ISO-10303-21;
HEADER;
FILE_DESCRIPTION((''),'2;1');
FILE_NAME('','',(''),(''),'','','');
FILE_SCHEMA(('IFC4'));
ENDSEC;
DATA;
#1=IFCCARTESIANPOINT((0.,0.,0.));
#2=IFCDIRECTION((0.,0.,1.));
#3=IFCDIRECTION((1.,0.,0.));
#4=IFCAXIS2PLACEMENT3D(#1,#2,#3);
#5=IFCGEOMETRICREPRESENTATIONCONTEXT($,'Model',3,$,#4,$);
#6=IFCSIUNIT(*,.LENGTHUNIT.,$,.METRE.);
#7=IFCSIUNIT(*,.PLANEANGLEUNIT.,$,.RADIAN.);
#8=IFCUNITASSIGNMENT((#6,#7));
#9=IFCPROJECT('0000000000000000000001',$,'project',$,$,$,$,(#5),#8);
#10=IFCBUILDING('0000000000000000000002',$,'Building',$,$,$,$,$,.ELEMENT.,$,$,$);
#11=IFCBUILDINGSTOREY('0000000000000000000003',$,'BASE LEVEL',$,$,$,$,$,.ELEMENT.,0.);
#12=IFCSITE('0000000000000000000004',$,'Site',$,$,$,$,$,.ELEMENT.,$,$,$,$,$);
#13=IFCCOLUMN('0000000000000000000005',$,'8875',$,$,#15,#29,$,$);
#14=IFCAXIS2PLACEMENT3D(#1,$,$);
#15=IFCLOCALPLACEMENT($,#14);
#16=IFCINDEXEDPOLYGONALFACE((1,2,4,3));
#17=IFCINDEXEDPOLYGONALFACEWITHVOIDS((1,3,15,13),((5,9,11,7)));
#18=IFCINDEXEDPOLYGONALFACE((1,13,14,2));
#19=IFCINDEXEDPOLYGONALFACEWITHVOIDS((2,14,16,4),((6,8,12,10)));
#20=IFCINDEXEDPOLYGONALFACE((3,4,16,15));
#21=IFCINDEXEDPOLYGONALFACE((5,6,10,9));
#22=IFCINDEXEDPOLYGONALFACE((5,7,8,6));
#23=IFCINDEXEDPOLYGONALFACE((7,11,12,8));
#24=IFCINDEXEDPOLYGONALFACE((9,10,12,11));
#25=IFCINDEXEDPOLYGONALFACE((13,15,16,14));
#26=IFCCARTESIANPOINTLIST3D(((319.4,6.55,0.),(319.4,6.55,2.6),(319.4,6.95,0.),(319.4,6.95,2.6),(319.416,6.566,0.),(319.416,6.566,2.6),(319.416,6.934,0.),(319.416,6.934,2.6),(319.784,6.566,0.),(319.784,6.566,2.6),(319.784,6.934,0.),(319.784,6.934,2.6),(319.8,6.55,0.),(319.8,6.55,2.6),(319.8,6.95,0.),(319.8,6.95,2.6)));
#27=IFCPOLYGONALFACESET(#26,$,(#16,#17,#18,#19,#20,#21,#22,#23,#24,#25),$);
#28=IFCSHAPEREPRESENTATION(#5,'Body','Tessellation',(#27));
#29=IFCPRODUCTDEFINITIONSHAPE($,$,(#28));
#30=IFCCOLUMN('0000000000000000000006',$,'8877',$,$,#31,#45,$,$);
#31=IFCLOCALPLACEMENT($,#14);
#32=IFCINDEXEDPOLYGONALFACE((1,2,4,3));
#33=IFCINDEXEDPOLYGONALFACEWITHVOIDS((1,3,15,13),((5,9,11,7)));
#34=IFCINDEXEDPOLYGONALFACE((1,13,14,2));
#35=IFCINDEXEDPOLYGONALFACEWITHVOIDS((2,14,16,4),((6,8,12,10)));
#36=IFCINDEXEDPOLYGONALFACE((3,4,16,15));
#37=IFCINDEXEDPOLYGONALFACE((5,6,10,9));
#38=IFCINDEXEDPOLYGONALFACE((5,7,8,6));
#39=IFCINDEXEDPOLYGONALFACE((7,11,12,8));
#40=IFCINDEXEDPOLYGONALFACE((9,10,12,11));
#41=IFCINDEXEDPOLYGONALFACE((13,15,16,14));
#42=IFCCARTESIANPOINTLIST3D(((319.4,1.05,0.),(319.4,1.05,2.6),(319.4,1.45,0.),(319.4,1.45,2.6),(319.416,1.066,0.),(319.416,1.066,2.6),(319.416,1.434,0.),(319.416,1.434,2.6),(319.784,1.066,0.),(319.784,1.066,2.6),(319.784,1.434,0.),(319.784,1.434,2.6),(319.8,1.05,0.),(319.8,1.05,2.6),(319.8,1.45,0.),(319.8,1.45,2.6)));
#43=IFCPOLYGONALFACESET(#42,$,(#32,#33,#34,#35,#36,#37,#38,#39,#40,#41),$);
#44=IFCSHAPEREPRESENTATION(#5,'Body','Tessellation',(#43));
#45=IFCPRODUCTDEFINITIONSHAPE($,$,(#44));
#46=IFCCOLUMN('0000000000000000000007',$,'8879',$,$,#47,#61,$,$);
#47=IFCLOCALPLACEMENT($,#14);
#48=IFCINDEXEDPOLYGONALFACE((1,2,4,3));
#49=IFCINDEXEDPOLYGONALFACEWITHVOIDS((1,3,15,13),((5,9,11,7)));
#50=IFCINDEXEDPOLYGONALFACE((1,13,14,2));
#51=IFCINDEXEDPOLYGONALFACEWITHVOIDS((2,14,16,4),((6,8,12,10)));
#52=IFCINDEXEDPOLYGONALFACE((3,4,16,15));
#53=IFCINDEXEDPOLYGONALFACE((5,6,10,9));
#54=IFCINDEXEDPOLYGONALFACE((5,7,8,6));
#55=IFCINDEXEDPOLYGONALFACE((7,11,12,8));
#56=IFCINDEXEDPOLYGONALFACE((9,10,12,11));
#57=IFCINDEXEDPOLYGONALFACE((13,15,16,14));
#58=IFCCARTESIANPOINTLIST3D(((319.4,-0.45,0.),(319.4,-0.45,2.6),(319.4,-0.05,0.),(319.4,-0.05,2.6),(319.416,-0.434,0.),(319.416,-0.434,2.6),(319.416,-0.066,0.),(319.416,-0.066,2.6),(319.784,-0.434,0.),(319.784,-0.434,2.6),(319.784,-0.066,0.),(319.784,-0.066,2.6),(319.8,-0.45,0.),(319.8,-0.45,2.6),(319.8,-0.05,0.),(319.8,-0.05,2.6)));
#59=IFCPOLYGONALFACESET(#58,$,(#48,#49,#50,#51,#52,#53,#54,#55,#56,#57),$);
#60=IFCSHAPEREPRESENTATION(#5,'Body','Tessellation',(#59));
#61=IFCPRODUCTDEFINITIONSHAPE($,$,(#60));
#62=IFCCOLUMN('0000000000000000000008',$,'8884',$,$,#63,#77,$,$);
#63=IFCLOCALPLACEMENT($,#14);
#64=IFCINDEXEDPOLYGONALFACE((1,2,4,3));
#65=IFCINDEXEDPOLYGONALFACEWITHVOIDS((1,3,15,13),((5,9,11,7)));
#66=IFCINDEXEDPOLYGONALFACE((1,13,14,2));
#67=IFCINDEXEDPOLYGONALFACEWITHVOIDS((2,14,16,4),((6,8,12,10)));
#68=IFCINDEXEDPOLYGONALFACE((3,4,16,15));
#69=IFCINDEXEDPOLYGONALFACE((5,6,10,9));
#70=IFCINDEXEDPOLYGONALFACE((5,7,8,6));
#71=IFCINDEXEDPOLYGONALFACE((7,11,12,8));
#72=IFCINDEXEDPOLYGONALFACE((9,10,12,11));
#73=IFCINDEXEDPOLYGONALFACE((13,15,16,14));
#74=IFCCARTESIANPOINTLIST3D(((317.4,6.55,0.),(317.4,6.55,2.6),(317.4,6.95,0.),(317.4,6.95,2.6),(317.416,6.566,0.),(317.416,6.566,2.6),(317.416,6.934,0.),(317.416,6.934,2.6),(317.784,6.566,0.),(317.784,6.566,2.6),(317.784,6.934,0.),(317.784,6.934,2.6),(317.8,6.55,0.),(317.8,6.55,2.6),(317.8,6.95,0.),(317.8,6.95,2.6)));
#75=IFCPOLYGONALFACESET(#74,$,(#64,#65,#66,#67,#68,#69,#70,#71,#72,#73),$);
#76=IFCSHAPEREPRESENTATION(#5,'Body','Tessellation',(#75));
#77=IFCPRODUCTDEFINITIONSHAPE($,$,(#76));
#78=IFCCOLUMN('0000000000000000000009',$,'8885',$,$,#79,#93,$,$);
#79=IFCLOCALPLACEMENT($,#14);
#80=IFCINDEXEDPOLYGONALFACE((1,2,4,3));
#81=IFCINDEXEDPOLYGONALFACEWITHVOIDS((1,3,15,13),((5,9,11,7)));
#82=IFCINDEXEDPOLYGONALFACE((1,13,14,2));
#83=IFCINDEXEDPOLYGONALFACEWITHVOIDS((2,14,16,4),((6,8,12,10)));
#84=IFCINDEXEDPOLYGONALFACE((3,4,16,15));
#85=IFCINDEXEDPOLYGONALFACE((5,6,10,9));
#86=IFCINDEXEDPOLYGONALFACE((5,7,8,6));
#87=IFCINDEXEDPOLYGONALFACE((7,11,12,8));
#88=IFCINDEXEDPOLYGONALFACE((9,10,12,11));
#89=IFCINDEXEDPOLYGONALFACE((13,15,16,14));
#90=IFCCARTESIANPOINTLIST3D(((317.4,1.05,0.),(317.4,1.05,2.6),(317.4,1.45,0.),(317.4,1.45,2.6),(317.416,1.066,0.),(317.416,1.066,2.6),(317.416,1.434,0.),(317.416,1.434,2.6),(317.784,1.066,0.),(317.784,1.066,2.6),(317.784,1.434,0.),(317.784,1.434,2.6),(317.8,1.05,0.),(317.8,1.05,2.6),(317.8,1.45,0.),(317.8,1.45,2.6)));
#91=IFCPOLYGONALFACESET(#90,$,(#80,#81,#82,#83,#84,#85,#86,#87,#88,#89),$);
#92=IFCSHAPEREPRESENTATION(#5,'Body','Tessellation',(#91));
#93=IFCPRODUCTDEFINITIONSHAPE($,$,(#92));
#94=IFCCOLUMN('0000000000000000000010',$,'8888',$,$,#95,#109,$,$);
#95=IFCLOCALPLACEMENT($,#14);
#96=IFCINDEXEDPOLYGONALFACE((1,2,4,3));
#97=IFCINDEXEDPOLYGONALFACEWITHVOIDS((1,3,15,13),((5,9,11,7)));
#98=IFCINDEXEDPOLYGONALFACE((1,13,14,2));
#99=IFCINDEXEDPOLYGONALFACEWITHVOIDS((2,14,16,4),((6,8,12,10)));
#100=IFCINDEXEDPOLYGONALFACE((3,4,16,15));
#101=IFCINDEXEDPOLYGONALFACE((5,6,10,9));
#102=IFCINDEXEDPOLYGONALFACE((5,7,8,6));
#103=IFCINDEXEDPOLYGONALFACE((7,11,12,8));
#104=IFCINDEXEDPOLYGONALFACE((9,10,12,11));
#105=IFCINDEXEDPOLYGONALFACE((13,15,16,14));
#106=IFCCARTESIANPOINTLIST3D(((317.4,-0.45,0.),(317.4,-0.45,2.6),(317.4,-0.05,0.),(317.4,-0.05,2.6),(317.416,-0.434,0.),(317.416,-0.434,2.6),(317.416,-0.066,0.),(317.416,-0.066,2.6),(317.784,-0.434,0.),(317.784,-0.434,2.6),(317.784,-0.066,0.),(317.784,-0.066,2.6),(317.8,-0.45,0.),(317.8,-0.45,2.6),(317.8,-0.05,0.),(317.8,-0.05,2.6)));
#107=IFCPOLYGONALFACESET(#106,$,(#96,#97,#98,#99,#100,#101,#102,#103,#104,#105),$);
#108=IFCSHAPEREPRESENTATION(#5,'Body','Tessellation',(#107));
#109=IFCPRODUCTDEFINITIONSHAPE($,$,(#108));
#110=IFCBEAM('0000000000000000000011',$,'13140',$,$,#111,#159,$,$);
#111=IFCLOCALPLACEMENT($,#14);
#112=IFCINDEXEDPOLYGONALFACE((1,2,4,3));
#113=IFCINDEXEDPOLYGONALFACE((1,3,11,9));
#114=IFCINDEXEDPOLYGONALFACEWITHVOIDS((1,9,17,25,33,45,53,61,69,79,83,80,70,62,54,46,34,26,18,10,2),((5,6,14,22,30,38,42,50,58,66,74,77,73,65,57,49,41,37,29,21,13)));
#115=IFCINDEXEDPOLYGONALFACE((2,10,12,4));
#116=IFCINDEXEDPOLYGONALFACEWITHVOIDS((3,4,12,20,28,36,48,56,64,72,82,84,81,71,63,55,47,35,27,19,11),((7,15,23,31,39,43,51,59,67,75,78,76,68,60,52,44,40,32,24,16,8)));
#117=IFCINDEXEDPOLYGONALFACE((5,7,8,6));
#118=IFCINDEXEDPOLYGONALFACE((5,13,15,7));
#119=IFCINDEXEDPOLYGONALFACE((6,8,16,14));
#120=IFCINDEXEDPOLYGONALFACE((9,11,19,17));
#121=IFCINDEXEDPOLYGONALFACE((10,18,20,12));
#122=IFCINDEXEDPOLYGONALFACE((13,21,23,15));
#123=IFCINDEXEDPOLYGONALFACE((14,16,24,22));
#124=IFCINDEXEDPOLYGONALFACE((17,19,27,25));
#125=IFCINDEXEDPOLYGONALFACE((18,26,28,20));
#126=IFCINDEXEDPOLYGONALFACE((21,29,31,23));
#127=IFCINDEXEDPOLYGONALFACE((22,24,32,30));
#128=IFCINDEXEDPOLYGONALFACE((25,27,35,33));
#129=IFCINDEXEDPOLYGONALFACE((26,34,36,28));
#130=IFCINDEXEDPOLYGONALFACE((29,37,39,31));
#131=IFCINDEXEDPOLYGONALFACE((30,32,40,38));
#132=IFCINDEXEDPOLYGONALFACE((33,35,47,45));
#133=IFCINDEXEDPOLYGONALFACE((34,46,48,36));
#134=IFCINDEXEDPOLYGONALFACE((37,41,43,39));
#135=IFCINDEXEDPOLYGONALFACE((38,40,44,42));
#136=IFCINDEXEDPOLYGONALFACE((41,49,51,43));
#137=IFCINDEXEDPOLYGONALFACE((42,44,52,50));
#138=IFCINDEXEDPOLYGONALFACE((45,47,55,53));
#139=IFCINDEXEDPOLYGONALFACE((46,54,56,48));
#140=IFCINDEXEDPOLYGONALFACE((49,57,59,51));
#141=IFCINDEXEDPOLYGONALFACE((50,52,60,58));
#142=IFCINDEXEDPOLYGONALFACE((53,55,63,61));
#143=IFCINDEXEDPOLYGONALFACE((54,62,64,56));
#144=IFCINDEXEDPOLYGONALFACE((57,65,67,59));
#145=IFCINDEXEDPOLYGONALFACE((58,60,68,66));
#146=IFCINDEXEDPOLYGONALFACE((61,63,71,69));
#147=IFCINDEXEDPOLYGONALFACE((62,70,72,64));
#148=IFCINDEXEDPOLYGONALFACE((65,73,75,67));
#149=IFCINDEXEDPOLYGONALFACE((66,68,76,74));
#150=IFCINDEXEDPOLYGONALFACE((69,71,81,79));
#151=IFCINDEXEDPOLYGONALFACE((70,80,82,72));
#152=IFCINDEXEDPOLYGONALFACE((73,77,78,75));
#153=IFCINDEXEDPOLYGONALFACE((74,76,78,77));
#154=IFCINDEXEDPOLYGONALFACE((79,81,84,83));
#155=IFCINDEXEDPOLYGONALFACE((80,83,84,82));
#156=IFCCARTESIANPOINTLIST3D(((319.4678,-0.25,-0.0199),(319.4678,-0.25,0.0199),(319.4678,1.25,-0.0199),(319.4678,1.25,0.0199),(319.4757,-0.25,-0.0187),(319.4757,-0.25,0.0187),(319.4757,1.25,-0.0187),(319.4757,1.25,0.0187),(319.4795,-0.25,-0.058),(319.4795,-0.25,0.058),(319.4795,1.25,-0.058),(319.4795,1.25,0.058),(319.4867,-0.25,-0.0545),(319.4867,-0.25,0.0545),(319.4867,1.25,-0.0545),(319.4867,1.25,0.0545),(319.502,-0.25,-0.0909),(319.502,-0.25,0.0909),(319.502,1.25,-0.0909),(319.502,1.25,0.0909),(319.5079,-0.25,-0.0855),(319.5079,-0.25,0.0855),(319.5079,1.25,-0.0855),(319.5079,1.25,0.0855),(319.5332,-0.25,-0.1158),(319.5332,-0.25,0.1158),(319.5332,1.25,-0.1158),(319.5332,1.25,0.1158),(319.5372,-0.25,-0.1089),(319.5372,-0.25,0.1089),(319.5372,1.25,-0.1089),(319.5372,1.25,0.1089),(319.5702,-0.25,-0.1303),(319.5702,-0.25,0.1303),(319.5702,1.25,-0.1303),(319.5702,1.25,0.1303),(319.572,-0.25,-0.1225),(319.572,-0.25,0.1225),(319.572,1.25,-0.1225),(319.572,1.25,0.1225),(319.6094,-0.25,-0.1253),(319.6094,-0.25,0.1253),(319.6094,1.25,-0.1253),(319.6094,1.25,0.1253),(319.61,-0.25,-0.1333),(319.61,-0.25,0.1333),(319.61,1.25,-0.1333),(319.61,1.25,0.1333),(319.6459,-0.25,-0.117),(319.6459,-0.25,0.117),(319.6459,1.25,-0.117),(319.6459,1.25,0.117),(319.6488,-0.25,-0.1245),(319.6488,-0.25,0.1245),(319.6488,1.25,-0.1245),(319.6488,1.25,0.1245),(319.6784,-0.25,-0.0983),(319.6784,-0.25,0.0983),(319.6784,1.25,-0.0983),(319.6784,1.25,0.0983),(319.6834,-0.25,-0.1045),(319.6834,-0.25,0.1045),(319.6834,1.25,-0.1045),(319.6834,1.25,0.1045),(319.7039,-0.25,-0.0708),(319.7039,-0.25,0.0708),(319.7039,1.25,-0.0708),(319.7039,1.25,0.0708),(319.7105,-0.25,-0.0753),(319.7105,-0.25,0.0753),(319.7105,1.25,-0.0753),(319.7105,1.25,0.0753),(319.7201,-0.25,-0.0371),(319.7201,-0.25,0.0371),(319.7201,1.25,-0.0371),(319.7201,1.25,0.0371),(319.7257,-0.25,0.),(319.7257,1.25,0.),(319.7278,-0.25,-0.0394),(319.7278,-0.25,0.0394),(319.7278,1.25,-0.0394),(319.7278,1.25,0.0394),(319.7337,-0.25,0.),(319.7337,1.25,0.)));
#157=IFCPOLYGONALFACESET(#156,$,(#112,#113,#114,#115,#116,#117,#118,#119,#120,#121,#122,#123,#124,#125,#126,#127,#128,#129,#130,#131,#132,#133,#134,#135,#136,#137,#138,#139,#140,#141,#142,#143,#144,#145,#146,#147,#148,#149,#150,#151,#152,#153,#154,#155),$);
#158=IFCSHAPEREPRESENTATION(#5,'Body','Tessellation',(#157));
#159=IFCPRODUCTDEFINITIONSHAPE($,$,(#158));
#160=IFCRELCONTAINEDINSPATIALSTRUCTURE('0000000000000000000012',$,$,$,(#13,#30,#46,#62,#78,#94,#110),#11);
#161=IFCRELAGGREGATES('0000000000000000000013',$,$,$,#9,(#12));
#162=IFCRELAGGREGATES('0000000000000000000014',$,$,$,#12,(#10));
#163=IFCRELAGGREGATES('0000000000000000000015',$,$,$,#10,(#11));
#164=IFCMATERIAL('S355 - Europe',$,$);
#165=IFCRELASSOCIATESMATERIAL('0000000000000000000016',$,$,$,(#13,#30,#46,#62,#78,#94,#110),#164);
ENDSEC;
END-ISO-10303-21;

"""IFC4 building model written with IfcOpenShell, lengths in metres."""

from ifc_helpers import new_model, si_unit, frame, origin_with_axes, origin_2d_with_axis, place, context, project, spatial, hollow_rectangle, hollow_circle, extrude, material, material_profile, profile_set, profile_usage, element, save


model = new_model("IFC4")

# Units and contexts
model_context = context("Model", 3, world=origin_with_axes())
ifc_project = project(units=[si_unit("LENGTHUNIT", "METRE"), si_unit("PLANEANGLEUNIT", "RADIAN")], contexts=[model_context])

# Site, building, storey
site = spatial("IfcSite", under=ifc_project, Name="Site", CompositionType="ELEMENT")
building = spatial("IfcBuilding", under=site, Name="Building", CompositionType="ELEMENT")
storey = spatial("IfcBuildingStorey", under=building, Name="BASE LEVEL", CompositionType="ELEMENT", Elevation=0.0)

# Columns
ifc_material = material(Name="S355 - Europe")
ifc_material_profile_1 = material_profile(ifc_material, hollow_rectangle(XDim=0.4, YDim=0.4, WallThickness=0.016, at=origin_2d_with_axis()))
ifc_profile_set_1 = profile_set([ifc_material_profile_1])
ifc_profile_usage_1 = profile_usage(ifc_profile_set_1, cardinal=10)
column_1_placement = place(None, frame((319.6, 6.75, 0.0), z_axis=(0.0, 0.0, 1.0), x_axis=(0.0, -1.0, 0.0)))
element("IfcColumn", 1, at=column_1_placement, inside=storey, material=ifc_profile_usage_1, Name="8875", context=model_context, shape_type="SweptSolid", body=[
    extrude(hollow_rectangle(XDim=0.4, YDim=0.4, WallThickness=0.016, at=origin_2d_with_axis()), origin_with_axes(), (0.0, 0.0, 1.0), 2.6),
])
ifc_material_profile_2 = material_profile(ifc_material, hollow_rectangle(XDim=0.4, YDim=0.4, WallThickness=0.016, at=origin_2d_with_axis()))
ifc_profile_set_2 = profile_set([ifc_material_profile_2])
ifc_profile_usage_2 = profile_usage(ifc_profile_set_2, cardinal=10)
column_2_placement = place(None, frame((319.6, 1.25, 0.0), z_axis=(0.0, 0.0, 1.0), x_axis=(0.0, -1.0, 0.0)))
element("IfcColumn", 2, at=column_2_placement, inside=storey, material=ifc_profile_usage_2, Name="8877", context=model_context, shape_type="SweptSolid", body=[
    extrude(hollow_rectangle(XDim=0.4, YDim=0.4, WallThickness=0.016, at=origin_2d_with_axis()), origin_with_axes(), (0.0, 0.0, 1.0), 2.6),
])
ifc_material_profile_3 = material_profile(ifc_material, hollow_rectangle(XDim=0.4, YDim=0.4, WallThickness=0.016, at=origin_2d_with_axis()))
ifc_profile_set_3 = profile_set([ifc_material_profile_3])
ifc_profile_usage_3 = profile_usage(ifc_profile_set_3, cardinal=10)
column_3_placement = place(None, frame((319.6, -0.25, 0.0), z_axis=(0.0, 0.0, 1.0), x_axis=(0.0, -1.0, 0.0)))
element("IfcColumn", 3, at=column_3_placement, inside=storey, material=ifc_profile_usage_3, Name="8879", context=model_context, shape_type="SweptSolid", body=[
    extrude(hollow_rectangle(XDim=0.4, YDim=0.4, WallThickness=0.016, at=origin_2d_with_axis()), origin_with_axes(), (0.0, 0.0, 1.0), 2.6),
])
ifc_material_profile_4 = material_profile(ifc_material, hollow_rectangle(XDim=0.4, YDim=0.4, WallThickness=0.016, at=origin_2d_with_axis()))
ifc_profile_set_4 = profile_set([ifc_material_profile_4])
ifc_profile_usage_4 = profile_usage(ifc_profile_set_4, cardinal=10)
column_4_placement = place(None, frame((317.6, 6.75, 0.0), z_axis=(0.0, 0.0, 1.0), x_axis=(0.0, -1.0, 0.0)))
element("IfcColumn", 4, at=column_4_placement, inside=storey, material=ifc_profile_usage_4, Name="8884", context=model_context, shape_type="SweptSolid", body=[
    extrude(hollow_rectangle(XDim=0.4, YDim=0.4, WallThickness=0.016, at=origin_2d_with_axis()), origin_with_axes(), (0.0, 0.0, 1.0), 2.6),
])
ifc_material_profile_5 = material_profile(ifc_material, hollow_rectangle(XDim=0.4, YDim=0.4, WallThickness=0.016, at=origin_2d_with_axis()))
ifc_profile_set_5 = profile_set([ifc_material_profile_5])
ifc_profile_usage_5 = profile_usage(ifc_profile_set_5, cardinal=10)
column_5_placement = place(None, frame((317.6, 1.25, 0.0), z_axis=(0.0, 0.0, 1.0), x_axis=(0.0, -1.0, 0.0)))
element("IfcColumn", 5, at=column_5_placement, inside=storey, material=ifc_profile_usage_5, Name="8885", context=model_context, shape_type="SweptSolid", body=[
    extrude(hollow_rectangle(XDim=0.4, YDim=0.4, WallThickness=0.016, at=origin_2d_with_axis()), origin_with_axes(), (0.0, 0.0, 1.0), 2.6),
])
ifc_material_profile_6 = material_profile(ifc_material, hollow_rectangle(XDim=0.4, YDim=0.4, WallThickness=0.016, at=origin_2d_with_axis()))
ifc_profile_set_6 = profile_set([ifc_material_profile_6])
ifc_profile_usage_6 = profile_usage(ifc_profile_set_6, cardinal=10)
column_6_placement = place(None, frame((317.6, -0.25, 0.0), z_axis=(0.0, 0.0, 1.0), x_axis=(0.0, -1.0, 0.0)))
element("IfcColumn", 6, at=column_6_placement, inside=storey, material=ifc_profile_usage_6, Name="8888", context=model_context, shape_type="SweptSolid", body=[
    extrude(hollow_rectangle(XDim=0.4, YDim=0.4, WallThickness=0.016, at=origin_2d_with_axis()), origin_with_axes(), (0.0, 0.0, 1.0), 2.6),
])

# Beam
ifc_material_profile_7 = material_profile(ifc_material, hollow_circle(Radius=0.1337, WallThickness=0.008, at=origin_2d_with_axis()))
ifc_profile_set_7 = profile_set([ifc_material_profile_7])
ifc_profile_usage_7 = profile_usage(ifc_profile_set_7, cardinal=10)
beam_1_placement = place(None, frame((319.6, 1.25, 0.0), z_axis=(0.0, -1.0, 0.0), x_axis=(1.0, 0.0, 0.0)))
element("IfcBeam", 7, at=beam_1_placement, inside=storey, material=ifc_profile_usage_7, Name="13140", context=model_context, shape_type="SweptSolid", body=[
    extrude(hollow_circle(Radius=0.1337, WallThickness=0.008, at=origin_2d_with_axis()), origin_with_axes(), (0.0, 0.0, 1.0), 1.5),
])

save(model, "model.ifc")
